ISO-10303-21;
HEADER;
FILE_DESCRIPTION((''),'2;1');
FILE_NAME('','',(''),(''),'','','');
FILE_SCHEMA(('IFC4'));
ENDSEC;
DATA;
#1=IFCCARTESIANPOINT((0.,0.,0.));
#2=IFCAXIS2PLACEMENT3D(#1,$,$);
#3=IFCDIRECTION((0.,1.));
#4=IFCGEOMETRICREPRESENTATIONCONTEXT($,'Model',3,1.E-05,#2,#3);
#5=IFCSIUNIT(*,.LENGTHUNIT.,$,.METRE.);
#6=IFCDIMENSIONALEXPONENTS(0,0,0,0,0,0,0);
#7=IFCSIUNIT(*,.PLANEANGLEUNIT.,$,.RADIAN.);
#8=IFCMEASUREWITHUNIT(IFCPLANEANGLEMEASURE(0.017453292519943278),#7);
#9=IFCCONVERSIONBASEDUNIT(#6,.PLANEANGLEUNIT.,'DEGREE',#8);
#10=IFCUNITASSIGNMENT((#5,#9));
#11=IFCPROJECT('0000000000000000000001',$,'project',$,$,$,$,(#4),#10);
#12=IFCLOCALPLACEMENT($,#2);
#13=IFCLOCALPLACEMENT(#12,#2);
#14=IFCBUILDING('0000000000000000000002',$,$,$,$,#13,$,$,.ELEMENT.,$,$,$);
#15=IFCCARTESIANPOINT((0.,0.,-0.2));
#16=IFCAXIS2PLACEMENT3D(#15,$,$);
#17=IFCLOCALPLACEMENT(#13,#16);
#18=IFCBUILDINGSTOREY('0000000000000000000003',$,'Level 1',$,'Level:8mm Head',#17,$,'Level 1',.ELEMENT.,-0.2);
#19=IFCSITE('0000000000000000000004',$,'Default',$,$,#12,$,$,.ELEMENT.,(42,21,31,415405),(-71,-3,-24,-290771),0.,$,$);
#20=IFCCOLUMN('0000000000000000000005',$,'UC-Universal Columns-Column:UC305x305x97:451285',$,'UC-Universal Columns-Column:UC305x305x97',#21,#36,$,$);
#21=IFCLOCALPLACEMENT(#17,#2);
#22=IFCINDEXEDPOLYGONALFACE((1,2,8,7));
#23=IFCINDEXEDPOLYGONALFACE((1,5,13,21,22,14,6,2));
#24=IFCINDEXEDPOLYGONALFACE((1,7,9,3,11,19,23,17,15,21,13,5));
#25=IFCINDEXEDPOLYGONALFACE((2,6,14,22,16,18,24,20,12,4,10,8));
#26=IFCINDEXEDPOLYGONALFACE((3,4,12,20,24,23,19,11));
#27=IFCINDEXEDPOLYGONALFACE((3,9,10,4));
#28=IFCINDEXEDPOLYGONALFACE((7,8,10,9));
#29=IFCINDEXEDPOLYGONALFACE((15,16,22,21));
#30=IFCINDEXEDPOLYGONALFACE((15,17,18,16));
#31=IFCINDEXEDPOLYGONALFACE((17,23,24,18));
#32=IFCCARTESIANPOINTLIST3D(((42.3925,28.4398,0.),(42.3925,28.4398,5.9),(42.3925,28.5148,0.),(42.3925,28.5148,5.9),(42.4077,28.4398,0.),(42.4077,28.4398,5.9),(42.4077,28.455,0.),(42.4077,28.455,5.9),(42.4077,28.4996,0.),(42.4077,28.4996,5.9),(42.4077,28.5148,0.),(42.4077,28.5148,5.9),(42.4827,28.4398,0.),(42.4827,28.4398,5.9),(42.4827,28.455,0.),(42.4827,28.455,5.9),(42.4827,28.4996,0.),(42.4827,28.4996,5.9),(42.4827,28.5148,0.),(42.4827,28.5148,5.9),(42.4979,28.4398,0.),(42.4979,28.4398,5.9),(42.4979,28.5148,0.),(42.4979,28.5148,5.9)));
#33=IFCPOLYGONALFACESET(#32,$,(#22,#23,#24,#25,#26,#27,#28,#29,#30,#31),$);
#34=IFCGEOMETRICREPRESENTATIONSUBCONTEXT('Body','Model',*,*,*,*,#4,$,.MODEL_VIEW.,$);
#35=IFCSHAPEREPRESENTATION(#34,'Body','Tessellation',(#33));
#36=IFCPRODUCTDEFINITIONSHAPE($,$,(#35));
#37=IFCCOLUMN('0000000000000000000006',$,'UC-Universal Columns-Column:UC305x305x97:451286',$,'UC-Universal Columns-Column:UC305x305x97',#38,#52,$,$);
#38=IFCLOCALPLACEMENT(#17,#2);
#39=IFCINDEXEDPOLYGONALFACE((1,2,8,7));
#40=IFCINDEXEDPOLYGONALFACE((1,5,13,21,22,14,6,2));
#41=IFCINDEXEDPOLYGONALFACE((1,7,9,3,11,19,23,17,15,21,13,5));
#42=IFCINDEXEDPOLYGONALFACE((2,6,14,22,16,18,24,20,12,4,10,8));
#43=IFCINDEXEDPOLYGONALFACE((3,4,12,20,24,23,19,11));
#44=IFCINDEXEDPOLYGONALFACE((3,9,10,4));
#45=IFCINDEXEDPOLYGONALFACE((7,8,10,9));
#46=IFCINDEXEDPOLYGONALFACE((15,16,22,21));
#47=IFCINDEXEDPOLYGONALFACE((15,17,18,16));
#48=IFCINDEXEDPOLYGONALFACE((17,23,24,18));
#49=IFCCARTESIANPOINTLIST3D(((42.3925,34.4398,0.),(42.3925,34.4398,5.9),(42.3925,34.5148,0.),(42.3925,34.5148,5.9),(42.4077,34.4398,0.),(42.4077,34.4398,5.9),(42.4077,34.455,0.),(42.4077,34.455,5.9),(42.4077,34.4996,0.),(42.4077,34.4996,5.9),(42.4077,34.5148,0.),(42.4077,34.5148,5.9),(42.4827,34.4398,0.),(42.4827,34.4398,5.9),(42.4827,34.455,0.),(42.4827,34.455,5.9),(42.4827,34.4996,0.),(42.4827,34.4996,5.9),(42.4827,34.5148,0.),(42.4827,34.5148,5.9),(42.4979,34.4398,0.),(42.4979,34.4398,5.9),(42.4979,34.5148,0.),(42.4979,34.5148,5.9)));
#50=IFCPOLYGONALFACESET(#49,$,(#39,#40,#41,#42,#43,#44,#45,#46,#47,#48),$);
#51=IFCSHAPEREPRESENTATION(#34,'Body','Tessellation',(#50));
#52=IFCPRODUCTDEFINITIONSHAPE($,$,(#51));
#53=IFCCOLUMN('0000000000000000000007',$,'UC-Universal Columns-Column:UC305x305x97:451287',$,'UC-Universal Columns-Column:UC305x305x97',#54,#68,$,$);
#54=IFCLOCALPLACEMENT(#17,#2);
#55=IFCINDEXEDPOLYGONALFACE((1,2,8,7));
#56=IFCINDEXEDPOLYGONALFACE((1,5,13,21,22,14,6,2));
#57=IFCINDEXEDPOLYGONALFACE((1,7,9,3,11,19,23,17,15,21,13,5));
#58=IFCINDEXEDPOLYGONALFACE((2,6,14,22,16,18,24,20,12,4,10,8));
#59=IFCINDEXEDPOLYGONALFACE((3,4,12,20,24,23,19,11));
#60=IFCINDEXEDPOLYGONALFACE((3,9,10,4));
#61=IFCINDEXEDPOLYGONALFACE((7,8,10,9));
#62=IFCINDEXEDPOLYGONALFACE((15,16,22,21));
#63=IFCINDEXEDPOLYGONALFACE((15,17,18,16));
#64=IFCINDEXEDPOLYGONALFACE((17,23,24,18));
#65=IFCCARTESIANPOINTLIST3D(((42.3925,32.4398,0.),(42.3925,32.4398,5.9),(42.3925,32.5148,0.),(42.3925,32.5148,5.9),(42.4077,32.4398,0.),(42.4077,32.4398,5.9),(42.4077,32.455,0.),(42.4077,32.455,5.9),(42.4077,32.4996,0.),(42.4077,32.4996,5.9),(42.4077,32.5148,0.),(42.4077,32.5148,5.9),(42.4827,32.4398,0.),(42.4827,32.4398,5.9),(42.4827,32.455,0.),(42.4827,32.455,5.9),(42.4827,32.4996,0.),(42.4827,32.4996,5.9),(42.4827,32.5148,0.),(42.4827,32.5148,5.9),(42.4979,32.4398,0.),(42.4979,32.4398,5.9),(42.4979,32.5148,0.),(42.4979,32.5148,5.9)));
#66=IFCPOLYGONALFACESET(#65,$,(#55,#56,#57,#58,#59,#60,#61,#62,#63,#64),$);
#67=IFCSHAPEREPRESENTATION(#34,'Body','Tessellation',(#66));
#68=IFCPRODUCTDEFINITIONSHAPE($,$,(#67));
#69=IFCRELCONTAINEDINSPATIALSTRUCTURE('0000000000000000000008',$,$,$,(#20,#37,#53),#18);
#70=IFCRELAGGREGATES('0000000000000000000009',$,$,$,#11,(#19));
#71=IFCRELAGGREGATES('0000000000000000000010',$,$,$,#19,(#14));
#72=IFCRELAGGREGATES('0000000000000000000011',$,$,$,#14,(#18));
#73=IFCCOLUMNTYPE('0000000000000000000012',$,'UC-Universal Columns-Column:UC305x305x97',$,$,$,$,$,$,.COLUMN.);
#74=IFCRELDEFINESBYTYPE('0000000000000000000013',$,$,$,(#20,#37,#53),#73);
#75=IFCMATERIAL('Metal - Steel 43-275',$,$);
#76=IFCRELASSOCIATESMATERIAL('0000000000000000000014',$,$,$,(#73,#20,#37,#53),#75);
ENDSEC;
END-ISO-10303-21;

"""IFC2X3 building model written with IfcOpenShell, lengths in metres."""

from ifc_helpers import new_model, entity, si_unit, converted_unit, direction, frame, frame_2d, origin, place, context, subcontext, project, spatial, polyline, circle_curve, parameter, trimmed, segment, composite_curve, outline, extrude, source, transform, mapped, material, type_object, type_shapes, element, save


model = new_model("IFC2X3")

# Units and contexts
model_context = context("Model", 3, precision=1e-05, world=origin(), true_north=direction((0.0, 1.0)))
body_context = subcontext(model_context, "Body", "Model", "MODEL_VIEW")
ifc_project = project(units=[si_unit("LENGTHUNIT", "METRE"), converted_unit("PLANEANGLEUNIT", "DEGREE", entity("IfcPlaneAngleMeasure", 0.017453292519943278), si_unit("PLANEANGLEUNIT", "RADIAN"), dimensions=[0, 0, 0, 0, 0, 0, 0])], contexts=[model_context])

# Site, building, storey
site_placement = place(None, origin())
site = spatial("IfcSite", under=ifc_project, at=site_placement, Name="Default", CompositionType="ELEMENT", RefLatitude=(42, 21, 31, 415405), RefLongitude=(-71, -3, -24, -290771), RefElevation=0.0)
building_placement = place(site_placement, origin())
building = spatial("IfcBuilding", under=site, at=building_placement, CompositionType="ELEMENT")
storey_placement = place(building_placement, frame((0.0, 0.0, -0.2)))
storey = spatial("IfcBuildingStorey", under=building, at=storey_placement, Name="Level 1", ObjectType="Level:8mm Head", LongName="Level 1", CompositionType="ELEMENT", Elevation=-0.2)

# Columns
ifc_material = material(Name="Metal - Steel 43-275")
column_type = type_object("IfcColumnType", Name="UC-Universal Columns-Column:UC305x305x97", PredefinedType="COLUMN", material=ifc_material)
shared_shape = source(origin(), body_context, "Body", "SweptSolid", [
    extrude(outline(composite_curve([segment(polyline([(-0.0375, -0.0375), (0.0375, -0.0375)]), True, "CONTINUOUS"), segment(polyline([(0.0375, -0.0375), (0.0527, -0.0375)]), True, "CONTINUOUS"), segment(trimmed(circle_curve(frame_2d((0.0527, -0.0223), x_axis=(-1.0, 0.0)), 0.0152), [parameter(0.0)], [parameter(90.0)], True, "PARAMETER"), False, "CONTINUOUS"), segment(polyline([(0.0375, -0.0223), (0.0375, 0.0223)]), True, "CONTINUOUS"), segment(trimmed(circle_curve(frame_2d((0.0527, 0.0223), x_axis=(-1.0, 0.0)), 0.0152), [parameter(270.0)], [parameter(0.0)], True, "PARAMETER"), False, "CONTINUOUS"), segment(polyline([(0.0527, 0.0375), (0.0375, 0.0375)]), True, "CONTINUOUS"), segment(polyline([(0.0375, 0.0375), (-0.0375, 0.0375)]), True, "CONTINUOUS"), segment(polyline([(-0.0375, 0.0375), (-0.0527, 0.0375)]), True, "CONTINUOUS"), segment(trimmed(circle_curve(frame_2d((-0.0527, 0.0223), x_axis=(-1.0, 0.0)), 0.0152), [parameter(180.0)], [parameter(270.0)], True, "PARAMETER"), False, "CONTINUOUS"), segment(polyline([(-0.0375, 0.0223), (-0.0375, -0.0223)]), True, "CONTINUOUS"), segment(trimmed(circle_curve(frame_2d((-0.0527, -0.0223), x_axis=(-1.0, 0.0)), 0.0152), [parameter(90.0)], [parameter(180.0)], True, "PARAMETER"), False, "CONTINUOUS"), segment(polyline([(-0.0527, -0.0375), (-0.0375, -0.0375)]), True, "CONTINUOUS")], self_intersect=False)), frame((0.0, 0.0, -0.2), z_axis=(0.0, 0.0, 1.0), x_axis=(-1.0, 0.0, 0.0)), (0.0, 0.0, 1.0), 5.9),
])
type_shapes(column_type, [shared_shape])
for number, where, z_axis, x_axis, name in (
    (1, (42.4452, 28.4773, 0.2), (0.0, 0.0, 1.0), (-1.0, 0.0, 0.0), "UC-Universal Columns-Column:UC305x305x97:451285"),
    (2, (42.4452, 34.4773, 0.2), (0.0, 0.0, 1.0), (-1.0, 0.0, 0.0), "UC-Universal Columns-Column:UC305x305x97:451286"),
    (3, (42.4452, 32.4773, 0.2), (0.0, 0.0, 1.0), (-1.0, 0.0, 0.0), "UC-Universal Columns-Column:UC305x305x97:451287"),
):
    element("IfcColumn", number, at=place(storey_placement, frame(where, z_axis=z_axis, x_axis=x_axis)), inside=storey, type_object=column_type, material=ifc_material, Name=name, ObjectType="UC-Universal Columns-Column:UC305x305x97", context=body_context, shape_type="MappedRepresentation", body=[
        mapped(shared_shape, transform((0.0, 0.0, 0.0), scale=1.0)),
    ])

save(model, "model.ifc")
